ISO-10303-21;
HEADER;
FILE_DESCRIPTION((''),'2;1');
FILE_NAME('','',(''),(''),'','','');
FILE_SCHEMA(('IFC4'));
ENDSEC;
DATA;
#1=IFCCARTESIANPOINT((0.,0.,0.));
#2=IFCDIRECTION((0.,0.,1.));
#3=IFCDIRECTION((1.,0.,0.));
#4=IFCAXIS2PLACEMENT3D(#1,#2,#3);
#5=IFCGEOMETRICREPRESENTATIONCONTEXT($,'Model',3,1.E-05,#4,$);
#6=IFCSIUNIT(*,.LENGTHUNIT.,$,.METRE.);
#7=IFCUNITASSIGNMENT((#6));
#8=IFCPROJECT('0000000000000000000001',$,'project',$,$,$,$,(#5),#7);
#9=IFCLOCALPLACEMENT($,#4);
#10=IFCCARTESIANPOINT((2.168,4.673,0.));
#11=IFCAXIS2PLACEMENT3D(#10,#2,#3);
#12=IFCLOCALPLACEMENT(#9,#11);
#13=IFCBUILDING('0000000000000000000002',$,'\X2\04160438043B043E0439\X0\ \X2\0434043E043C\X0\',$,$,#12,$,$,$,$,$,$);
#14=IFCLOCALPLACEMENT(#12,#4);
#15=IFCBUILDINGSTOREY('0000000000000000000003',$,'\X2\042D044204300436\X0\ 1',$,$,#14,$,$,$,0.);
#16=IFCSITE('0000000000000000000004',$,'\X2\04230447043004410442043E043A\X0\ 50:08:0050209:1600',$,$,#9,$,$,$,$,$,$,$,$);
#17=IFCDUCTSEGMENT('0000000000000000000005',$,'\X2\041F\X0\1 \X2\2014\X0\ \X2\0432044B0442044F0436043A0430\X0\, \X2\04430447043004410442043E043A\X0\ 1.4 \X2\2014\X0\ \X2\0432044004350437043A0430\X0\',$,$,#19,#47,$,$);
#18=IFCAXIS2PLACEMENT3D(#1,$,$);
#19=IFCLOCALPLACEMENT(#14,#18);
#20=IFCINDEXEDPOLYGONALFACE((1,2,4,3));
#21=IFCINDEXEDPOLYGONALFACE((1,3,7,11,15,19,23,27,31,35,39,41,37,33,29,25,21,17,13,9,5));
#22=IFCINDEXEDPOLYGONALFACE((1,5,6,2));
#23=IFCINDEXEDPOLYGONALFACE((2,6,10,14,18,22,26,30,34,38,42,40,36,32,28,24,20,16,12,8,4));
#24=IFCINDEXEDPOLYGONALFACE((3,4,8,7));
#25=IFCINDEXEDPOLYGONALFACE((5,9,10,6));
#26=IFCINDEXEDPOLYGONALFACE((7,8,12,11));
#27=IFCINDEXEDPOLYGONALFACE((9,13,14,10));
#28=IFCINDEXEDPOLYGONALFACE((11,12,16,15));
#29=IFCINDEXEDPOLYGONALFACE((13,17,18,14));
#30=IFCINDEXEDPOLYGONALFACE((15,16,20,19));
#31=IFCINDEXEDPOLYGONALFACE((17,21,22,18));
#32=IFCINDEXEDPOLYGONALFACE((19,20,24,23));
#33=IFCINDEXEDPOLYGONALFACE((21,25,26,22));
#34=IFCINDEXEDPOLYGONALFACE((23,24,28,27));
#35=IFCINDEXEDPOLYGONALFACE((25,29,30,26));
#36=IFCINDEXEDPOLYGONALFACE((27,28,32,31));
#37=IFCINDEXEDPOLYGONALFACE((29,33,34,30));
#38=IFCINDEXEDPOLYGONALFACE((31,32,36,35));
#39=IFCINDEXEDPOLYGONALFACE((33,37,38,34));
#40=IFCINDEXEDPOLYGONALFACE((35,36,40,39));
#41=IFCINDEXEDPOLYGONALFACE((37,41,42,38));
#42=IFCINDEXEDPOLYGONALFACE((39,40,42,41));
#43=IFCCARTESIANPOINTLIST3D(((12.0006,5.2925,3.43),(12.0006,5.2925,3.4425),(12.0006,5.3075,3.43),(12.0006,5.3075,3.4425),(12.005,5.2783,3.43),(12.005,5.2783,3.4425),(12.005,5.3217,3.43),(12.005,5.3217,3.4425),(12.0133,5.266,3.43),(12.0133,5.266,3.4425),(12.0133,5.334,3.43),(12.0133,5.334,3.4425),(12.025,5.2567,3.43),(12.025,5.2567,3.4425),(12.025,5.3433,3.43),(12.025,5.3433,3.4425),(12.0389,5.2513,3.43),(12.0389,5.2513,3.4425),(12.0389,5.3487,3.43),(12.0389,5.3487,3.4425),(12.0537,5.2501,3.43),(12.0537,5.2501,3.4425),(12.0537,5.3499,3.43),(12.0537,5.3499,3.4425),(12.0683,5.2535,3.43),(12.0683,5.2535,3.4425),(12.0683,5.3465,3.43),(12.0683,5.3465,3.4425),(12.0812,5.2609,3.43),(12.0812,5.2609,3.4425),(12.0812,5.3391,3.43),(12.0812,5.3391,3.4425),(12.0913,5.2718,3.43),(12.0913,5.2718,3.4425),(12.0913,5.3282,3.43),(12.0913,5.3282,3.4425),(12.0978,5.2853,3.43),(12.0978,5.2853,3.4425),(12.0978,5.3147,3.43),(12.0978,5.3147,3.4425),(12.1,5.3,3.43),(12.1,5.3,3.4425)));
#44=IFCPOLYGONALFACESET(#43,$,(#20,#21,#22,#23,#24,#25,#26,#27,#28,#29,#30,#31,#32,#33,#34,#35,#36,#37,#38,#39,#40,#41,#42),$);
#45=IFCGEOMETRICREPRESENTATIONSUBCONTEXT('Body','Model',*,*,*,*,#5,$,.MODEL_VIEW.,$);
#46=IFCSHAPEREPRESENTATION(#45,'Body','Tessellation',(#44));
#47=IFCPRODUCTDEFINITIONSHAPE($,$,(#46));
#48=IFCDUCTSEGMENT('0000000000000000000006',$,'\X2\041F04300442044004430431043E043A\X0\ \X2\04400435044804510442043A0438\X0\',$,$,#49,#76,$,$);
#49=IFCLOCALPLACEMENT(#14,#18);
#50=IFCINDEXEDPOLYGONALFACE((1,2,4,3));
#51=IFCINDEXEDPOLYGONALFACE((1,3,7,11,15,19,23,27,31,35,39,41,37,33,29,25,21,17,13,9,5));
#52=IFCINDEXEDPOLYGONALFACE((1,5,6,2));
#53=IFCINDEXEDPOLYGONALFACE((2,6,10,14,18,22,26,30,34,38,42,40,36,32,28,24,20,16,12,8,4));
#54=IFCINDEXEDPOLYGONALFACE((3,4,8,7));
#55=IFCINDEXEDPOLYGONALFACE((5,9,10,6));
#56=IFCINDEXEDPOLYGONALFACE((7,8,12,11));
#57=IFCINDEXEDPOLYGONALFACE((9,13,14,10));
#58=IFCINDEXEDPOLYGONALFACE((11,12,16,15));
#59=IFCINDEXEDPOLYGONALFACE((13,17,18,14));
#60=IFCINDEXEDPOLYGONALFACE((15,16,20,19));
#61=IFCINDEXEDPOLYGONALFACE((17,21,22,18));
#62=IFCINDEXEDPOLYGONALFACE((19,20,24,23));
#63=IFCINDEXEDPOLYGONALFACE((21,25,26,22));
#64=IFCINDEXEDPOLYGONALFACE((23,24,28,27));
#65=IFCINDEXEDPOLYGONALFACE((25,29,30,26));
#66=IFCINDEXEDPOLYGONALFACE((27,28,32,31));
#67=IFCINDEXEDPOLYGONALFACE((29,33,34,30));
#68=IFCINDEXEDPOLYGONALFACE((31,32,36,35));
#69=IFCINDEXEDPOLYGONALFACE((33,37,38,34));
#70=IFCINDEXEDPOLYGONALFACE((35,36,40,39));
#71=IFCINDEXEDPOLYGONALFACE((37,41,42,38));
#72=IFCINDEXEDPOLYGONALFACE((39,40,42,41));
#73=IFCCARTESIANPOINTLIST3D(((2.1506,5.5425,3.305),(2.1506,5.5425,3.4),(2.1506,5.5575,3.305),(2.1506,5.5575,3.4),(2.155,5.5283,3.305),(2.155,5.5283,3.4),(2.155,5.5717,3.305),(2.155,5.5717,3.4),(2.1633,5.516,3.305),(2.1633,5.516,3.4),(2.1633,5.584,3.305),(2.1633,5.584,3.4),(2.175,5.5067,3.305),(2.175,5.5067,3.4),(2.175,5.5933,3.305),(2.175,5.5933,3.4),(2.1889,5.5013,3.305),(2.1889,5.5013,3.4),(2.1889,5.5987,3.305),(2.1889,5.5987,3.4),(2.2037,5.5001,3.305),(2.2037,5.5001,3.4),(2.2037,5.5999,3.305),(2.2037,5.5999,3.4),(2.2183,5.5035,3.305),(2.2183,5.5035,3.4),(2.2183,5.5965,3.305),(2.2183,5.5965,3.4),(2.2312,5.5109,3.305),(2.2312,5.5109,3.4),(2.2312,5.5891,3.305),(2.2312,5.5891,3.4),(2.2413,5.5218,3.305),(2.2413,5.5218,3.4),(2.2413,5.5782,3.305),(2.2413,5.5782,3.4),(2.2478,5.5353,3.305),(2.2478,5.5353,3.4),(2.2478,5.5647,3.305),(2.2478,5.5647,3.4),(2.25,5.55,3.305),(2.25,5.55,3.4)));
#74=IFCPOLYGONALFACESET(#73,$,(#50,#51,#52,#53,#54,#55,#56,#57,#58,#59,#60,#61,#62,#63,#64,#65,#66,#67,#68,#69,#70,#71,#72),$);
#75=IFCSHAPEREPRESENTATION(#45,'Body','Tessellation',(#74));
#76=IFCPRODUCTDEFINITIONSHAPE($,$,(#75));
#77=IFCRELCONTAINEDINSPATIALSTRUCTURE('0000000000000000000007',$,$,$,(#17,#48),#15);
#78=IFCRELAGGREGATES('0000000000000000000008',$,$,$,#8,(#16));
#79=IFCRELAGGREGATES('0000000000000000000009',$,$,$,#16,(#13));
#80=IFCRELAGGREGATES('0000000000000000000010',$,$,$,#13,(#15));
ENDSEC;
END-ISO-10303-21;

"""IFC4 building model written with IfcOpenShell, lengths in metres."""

from ifc_helpers import new_model, si_unit, frame, origin_with_axes, origin_2d, place, context, subcontext, project, spatial, circle, extrude, element, save


model = new_model("IFC4")

# Units and contexts
model_context = context("Model", 3, precision=1e-05, world=origin_with_axes())
body_context = subcontext(model_context, "Body", "Model", "MODEL_VIEW")
ifc_project = project(units=[si_unit("LENGTHUNIT", "METRE")], contexts=[model_context])

# Site, building, storey
site_placement = place(None, origin_with_axes())
site = spatial("IfcSite", under=ifc_project, at=site_placement, Name="Участок 50:08:0050209:1600")
building_placement = place(site_placement, frame((2.168, 4.673, 0.0), z_axis=(0.0, 0.0, 1.0), x_axis=(1.0, 0.0, 0.0)))
building = spatial("IfcBuilding", under=site, at=building_placement, Name="Жилой дом")
storey_placement = place(building_placement, origin_with_axes())
storey = spatial("IfcBuildingStorey", under=building, at=storey_placement, Name="Этаж 1", Elevation=0.0)

# Duct segments
for number, where, z_axis, x_axis, name in (
    (1, (0.0, 0.0, 0.0), (0.0, 0.0, 1.0), (1.0, 0.0, 0.0), "П1 — вытяжка, участок 1.4 — врезка"),
):
    element("IfcDuctSegment", number, at=place(storey_placement, frame(where, z_axis=z_axis, x_axis=x_axis)), inside=storey, Name=name, context=body_context, shape_type="SweptSolid", body=[
        extrude(circle(Radius=0.05, at=origin_2d()), frame((12.05, 5.3, 3.43), z_axis=(0.0, 0.0, 1.0), x_axis=(1.0, 0.0, 0.0)), (0.0, 0.0, 1.0), 0.0125),
    ])
duct_segment_1_placement = place(storey_placement, origin_with_axes())
element("IfcDuctSegment", 2, at=duct_segment_1_placement, inside=storey, Name="Патрубок решётки", context=body_context, shape_type="SweptSolid", body=[
    extrude(circle(Radius=0.05, at=origin_2d()), frame((2.2, 5.55, 3.4), z_axis=(0.0, 0.0, -1.0), x_axis=(1.0, 0.0, 0.0)), (0.0, 0.0, 1.0), 0.095),
])

save(model, "model.ifc")
